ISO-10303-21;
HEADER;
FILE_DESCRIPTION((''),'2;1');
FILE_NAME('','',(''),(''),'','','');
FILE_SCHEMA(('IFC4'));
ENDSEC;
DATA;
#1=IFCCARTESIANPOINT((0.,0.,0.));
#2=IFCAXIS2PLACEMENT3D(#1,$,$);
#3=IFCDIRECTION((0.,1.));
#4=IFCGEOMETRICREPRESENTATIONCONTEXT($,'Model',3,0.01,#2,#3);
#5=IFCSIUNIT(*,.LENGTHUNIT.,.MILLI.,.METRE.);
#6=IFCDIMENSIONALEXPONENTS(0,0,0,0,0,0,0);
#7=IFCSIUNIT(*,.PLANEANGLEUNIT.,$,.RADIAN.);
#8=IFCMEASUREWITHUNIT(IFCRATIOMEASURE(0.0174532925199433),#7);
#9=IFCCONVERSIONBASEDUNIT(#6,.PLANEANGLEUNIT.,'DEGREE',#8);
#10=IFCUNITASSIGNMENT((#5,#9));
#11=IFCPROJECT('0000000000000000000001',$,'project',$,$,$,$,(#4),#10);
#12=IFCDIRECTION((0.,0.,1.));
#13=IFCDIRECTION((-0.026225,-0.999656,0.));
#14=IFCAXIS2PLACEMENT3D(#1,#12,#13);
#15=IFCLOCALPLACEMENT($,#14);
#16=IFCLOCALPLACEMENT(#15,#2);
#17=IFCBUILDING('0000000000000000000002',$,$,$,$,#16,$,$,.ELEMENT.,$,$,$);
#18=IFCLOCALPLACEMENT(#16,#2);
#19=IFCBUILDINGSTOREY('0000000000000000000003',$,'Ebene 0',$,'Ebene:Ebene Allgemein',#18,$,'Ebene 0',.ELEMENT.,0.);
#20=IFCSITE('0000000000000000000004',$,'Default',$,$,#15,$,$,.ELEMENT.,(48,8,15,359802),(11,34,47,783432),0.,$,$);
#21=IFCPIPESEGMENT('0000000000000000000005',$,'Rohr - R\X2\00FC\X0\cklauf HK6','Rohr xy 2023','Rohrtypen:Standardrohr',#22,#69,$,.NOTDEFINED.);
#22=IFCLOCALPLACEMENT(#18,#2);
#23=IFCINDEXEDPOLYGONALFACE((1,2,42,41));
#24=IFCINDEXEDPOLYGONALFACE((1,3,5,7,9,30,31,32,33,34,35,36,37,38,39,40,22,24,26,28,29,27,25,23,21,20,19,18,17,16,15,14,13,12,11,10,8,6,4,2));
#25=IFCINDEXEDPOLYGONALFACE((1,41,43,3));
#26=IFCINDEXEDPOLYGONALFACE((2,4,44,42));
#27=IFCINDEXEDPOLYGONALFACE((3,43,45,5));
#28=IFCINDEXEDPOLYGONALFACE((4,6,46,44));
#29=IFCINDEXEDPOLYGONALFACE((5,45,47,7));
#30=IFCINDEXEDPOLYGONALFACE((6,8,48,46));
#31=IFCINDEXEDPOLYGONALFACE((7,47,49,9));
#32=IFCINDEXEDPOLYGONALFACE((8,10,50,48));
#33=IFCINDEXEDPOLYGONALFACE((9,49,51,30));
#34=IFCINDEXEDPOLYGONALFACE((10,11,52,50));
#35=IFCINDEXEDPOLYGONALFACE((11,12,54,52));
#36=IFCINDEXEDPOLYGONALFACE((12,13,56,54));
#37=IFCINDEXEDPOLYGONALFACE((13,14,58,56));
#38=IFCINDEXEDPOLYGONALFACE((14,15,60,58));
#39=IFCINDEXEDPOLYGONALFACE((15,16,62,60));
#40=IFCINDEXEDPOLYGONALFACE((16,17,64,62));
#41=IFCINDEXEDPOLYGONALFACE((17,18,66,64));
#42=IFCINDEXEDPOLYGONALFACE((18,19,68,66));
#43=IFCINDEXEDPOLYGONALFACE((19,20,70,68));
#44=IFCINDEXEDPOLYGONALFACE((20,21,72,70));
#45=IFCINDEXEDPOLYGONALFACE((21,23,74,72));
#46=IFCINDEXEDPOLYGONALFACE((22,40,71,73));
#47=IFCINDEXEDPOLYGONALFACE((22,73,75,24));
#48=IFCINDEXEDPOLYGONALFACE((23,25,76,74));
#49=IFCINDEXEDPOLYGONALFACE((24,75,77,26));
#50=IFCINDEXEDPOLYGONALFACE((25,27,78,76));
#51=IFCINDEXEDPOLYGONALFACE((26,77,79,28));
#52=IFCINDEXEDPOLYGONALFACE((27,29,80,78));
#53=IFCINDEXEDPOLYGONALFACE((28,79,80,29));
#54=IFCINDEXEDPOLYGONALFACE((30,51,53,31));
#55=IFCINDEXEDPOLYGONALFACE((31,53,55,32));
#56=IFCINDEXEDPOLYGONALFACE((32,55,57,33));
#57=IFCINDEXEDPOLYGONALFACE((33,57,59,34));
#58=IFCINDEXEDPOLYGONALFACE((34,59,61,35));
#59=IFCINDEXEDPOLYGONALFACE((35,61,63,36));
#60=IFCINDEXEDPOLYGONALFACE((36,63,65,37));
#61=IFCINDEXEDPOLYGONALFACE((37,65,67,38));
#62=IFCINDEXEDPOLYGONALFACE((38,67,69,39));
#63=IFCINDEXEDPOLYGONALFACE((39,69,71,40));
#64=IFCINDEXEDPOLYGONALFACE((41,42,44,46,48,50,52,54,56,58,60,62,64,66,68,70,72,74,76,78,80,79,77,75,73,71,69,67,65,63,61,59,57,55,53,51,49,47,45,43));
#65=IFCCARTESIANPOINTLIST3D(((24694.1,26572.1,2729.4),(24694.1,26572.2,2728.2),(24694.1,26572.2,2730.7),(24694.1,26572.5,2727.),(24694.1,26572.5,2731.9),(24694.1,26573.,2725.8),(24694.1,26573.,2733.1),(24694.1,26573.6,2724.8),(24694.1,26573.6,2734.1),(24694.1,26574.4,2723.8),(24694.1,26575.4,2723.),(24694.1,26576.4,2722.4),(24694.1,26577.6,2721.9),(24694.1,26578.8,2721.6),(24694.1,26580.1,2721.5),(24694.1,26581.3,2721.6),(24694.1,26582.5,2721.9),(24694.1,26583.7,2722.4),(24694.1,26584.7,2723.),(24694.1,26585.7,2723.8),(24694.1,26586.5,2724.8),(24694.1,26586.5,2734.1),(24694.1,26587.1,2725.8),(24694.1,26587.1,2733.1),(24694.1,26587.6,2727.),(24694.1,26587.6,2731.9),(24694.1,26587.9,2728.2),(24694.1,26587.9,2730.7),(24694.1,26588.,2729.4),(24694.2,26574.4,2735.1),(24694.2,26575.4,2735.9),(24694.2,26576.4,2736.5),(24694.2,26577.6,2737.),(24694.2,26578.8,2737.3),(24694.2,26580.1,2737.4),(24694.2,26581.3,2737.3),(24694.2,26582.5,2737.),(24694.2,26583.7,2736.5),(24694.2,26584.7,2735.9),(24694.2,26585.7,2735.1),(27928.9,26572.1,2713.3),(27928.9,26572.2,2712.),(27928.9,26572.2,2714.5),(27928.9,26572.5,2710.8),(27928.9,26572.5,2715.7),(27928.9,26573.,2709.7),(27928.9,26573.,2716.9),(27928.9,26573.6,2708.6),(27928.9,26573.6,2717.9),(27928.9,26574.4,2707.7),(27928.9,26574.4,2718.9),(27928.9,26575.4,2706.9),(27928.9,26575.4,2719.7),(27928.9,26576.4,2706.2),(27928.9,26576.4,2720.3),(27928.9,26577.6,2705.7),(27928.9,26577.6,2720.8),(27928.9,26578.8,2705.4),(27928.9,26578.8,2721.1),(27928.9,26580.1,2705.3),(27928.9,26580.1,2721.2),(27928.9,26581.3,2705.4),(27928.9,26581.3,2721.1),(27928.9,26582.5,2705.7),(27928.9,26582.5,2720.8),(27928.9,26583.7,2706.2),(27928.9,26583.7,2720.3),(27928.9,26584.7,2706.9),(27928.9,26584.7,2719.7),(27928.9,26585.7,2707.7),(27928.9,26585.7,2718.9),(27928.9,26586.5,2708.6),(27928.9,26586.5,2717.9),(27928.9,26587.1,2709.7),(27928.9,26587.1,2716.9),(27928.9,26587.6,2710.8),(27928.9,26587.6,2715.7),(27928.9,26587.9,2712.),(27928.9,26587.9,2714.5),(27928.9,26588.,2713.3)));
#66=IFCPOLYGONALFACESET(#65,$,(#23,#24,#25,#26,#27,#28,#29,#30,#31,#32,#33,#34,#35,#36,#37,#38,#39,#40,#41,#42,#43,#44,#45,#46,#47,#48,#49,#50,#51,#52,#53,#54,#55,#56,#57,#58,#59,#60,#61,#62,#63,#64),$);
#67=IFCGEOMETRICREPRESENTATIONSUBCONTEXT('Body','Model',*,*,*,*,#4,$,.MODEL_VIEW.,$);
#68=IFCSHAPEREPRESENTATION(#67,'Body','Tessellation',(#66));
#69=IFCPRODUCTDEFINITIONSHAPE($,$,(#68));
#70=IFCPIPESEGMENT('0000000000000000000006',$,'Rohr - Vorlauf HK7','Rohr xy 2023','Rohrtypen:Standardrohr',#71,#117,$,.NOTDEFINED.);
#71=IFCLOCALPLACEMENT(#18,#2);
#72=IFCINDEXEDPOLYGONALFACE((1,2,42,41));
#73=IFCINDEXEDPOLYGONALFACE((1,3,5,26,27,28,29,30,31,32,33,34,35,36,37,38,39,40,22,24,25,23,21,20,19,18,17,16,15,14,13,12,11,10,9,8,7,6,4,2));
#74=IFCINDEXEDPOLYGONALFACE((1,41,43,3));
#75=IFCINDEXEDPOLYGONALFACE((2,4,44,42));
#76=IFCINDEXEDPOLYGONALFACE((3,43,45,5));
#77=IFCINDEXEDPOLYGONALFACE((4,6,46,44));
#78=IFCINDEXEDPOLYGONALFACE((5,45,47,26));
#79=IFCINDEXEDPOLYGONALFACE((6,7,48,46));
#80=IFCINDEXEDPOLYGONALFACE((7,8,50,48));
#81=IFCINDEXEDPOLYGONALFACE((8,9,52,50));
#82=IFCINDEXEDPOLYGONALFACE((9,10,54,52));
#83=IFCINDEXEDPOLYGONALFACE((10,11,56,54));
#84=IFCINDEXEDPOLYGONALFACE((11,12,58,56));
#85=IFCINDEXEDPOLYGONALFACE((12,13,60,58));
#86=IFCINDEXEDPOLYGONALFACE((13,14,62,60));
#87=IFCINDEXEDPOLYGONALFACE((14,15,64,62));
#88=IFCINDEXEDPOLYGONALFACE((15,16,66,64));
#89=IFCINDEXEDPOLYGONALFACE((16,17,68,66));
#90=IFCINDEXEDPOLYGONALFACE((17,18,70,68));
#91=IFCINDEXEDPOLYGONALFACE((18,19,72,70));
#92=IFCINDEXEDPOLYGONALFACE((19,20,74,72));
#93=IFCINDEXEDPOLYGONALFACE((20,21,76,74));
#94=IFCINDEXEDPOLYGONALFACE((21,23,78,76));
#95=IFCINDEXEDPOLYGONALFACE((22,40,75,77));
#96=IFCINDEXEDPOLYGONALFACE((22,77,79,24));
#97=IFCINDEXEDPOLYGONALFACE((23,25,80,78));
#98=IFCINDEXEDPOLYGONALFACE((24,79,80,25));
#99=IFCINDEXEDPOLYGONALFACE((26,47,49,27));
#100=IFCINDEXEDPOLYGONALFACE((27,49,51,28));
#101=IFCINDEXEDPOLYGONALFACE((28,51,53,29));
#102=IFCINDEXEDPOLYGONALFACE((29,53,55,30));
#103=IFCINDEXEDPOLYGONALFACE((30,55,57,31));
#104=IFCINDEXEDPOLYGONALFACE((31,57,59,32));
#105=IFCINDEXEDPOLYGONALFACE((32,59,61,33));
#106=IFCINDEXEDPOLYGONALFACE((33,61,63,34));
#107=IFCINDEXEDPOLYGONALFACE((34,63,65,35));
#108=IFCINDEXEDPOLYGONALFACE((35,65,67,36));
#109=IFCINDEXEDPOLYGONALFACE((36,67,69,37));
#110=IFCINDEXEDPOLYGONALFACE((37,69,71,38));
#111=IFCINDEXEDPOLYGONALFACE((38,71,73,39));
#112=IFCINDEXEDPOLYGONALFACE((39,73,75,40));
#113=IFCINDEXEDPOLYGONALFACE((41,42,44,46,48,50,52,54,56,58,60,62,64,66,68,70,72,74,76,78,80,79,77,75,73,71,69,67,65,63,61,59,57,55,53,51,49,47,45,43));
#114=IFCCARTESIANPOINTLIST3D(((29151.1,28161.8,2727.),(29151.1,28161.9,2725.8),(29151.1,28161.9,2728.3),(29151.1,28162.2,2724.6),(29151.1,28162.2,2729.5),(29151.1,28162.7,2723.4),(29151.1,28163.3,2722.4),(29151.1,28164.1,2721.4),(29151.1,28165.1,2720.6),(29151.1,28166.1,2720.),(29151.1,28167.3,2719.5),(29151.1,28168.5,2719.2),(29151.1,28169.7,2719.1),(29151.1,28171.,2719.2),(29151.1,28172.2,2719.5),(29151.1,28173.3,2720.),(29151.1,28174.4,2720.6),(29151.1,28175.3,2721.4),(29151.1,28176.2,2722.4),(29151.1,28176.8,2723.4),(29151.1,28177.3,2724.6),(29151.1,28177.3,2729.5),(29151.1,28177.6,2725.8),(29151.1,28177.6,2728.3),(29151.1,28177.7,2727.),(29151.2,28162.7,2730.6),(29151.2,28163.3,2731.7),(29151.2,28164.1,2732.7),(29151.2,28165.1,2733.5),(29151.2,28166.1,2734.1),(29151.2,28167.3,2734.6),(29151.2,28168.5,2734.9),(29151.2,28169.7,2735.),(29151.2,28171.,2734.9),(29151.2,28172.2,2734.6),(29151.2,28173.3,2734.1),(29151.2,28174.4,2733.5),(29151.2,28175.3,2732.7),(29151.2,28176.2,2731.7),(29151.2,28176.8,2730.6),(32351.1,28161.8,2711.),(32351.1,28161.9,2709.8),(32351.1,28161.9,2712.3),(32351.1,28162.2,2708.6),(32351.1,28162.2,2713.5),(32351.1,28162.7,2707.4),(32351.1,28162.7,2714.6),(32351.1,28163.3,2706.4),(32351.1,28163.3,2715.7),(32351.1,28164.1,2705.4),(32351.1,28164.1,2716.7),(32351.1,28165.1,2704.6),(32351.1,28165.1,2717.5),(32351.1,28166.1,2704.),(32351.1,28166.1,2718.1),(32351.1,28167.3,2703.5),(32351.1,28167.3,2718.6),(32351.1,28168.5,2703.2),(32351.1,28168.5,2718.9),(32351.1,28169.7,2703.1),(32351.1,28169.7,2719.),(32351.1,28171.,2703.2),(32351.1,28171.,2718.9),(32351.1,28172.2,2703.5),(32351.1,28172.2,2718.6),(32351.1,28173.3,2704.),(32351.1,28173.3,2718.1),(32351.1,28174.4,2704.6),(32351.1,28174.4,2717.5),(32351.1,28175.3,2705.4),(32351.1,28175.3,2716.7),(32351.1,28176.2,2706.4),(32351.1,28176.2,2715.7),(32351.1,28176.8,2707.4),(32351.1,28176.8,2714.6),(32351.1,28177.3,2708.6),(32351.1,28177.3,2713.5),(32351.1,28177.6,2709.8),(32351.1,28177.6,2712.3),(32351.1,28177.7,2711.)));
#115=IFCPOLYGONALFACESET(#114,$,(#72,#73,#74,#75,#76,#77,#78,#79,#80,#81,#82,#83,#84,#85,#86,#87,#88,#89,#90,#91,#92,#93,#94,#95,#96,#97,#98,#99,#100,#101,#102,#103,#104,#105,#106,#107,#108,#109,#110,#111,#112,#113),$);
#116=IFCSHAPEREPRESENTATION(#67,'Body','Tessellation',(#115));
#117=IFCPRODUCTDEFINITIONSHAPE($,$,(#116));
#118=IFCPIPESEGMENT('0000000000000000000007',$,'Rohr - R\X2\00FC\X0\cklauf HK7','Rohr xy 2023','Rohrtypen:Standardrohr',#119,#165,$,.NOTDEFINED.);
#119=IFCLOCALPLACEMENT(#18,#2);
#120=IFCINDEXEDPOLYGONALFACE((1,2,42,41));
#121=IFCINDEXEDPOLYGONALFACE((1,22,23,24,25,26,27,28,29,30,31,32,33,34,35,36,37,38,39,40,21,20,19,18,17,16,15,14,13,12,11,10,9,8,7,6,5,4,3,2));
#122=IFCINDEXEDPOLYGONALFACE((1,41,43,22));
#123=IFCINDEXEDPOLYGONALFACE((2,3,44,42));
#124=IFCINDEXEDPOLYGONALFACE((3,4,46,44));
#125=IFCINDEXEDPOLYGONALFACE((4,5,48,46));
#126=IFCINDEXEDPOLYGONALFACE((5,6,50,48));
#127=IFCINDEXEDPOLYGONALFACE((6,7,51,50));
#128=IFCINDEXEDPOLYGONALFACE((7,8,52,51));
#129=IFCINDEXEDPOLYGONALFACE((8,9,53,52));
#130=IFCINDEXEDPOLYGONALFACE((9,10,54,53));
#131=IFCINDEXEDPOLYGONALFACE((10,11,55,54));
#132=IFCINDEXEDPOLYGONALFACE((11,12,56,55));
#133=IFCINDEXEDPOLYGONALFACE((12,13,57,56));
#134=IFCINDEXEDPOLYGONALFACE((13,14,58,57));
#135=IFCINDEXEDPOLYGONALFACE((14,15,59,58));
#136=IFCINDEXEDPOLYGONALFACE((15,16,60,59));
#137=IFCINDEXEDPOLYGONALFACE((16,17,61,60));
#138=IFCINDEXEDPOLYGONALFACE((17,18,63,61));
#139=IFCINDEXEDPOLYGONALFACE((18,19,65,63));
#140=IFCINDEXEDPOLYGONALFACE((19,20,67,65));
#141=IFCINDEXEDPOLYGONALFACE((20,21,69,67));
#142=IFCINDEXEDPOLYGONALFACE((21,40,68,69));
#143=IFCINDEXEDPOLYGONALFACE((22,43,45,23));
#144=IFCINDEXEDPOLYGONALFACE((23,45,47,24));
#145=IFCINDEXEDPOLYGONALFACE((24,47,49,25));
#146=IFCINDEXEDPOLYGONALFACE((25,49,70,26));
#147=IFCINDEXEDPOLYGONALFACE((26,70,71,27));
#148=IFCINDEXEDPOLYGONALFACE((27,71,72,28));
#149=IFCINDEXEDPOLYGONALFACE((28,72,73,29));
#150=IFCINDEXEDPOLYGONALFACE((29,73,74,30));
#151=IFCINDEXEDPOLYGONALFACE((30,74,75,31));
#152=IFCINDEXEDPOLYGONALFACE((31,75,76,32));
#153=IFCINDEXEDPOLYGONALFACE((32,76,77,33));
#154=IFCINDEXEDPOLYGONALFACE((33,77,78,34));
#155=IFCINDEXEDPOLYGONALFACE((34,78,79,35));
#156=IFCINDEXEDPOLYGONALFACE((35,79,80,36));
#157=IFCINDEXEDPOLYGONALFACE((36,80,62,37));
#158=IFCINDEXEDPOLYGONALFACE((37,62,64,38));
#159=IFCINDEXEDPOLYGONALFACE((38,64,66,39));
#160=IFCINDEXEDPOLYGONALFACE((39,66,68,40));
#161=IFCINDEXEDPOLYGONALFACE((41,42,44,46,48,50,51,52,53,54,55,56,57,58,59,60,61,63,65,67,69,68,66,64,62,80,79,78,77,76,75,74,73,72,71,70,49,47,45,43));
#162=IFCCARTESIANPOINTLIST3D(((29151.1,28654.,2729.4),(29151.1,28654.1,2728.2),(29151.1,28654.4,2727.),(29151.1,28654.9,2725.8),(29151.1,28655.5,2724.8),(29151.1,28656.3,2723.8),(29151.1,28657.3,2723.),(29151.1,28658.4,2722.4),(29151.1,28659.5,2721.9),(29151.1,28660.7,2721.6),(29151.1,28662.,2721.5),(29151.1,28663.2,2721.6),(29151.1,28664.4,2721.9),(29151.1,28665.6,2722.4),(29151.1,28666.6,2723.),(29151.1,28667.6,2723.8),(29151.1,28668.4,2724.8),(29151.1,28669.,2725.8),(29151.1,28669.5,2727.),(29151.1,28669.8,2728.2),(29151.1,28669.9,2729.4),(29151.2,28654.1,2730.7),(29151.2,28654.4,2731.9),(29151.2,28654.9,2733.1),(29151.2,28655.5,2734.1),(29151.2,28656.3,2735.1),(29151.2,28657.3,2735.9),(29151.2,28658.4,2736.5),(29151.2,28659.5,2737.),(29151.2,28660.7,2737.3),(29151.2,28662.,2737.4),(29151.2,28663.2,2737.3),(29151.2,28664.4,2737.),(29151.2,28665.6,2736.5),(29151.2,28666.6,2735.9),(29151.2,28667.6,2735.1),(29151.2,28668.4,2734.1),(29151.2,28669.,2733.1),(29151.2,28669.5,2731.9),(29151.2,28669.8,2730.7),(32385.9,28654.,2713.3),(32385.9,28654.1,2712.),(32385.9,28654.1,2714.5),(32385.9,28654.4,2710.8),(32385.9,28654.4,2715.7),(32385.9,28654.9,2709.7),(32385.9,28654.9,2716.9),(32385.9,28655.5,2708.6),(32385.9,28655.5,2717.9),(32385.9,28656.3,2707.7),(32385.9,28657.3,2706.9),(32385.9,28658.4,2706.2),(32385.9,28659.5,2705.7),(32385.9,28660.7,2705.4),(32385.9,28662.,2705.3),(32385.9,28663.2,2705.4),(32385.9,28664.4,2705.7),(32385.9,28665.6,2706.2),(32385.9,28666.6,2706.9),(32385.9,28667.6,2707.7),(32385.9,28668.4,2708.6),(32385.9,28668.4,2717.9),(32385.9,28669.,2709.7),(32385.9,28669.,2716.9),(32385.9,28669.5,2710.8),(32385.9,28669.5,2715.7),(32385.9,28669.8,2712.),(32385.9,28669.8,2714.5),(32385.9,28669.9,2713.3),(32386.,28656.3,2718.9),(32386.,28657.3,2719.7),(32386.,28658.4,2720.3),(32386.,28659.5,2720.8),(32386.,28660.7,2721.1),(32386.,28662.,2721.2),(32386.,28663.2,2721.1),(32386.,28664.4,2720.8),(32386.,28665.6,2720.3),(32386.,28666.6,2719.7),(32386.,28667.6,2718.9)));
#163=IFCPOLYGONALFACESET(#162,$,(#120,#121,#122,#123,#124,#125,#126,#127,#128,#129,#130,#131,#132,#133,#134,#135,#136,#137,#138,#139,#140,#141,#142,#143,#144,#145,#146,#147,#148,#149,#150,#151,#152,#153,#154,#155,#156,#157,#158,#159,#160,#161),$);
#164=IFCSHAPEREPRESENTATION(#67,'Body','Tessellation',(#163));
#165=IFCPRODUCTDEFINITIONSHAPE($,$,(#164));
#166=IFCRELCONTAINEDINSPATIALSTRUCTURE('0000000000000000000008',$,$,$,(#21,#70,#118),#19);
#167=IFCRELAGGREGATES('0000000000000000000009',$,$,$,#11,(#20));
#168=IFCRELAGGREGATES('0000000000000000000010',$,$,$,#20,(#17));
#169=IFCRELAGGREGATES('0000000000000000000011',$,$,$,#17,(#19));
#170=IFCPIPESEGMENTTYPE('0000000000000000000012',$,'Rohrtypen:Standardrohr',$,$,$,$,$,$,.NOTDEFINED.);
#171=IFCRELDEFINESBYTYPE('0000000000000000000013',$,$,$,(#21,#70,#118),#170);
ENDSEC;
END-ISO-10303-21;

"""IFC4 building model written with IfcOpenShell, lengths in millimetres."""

from ifc_helpers import new_model, entity, si_unit, converted_unit, direction, frame, origin, place, context, subcontext, project, spatial, indexed_curve, outline, extrude, type_object, element, save


model = new_model("IFC4")

# Units and contexts
model_context = context("Model", 3, precision=0.01, world=origin(), true_north=direction((0.0, 1.0)))
body_context = subcontext(model_context, "Body", "Model", "MODEL_VIEW")
ifc_project = project(units=[si_unit("LENGTHUNIT", "METRE", prefix="MILLI"), converted_unit("PLANEANGLEUNIT", "DEGREE", entity("IfcRatioMeasure", 0.0174532925199433), si_unit("PLANEANGLEUNIT", "RADIAN"), dimensions=[0, 0, 0, 0, 0, 0, 0])], contexts=[model_context])

# Site, building, storey
site_placement = place(None, frame((0.0, 0.0, 0.0), z_axis=(0.0, 0.0, 1.0), x_axis=(-0.026225, -0.999656, 0.0)))
site = spatial("IfcSite", under=ifc_project, at=site_placement, Name="Default", CompositionType="ELEMENT", RefLatitude=(48, 8, 15, 359802), RefLongitude=(11, 34, 47, 783432), RefElevation=0.0)
building_placement = place(site_placement, origin())
building = spatial("IfcBuilding", under=site, at=building_placement, CompositionType="ELEMENT")
storey_placement = place(building_placement, origin())
storey = spatial("IfcBuildingStorey", under=building, at=storey_placement, Name="Ebene 0", ObjectType="Ebene:Ebene Allgemein", LongName="Ebene 0", CompositionType="ELEMENT", Elevation=0.0)

# Pipe segments
pipe_segment_type = type_object("IfcPipeSegmentType", Name="Rohrtypen:Standardrohr", PredefinedType="NOTDEFINED")
pipe_segment_1_placement = place(storey_placement, origin())
element("IfcPipeSegment", 1, at=pipe_segment_1_placement, inside=storey, type_object=pipe_segment_type, Name="Rohr - Rücklauf HK6", Description="Rohr xy 2023", ObjectType="Rohrtypen:Standardrohr", PredefinedType="NOTDEFINED", context=body_context, shape_type="SweptSolid", body=[
    extrude(outline(indexed_curve([(7.9, 0.0), (7.8, 1.2), (7.6, 2.5), (7.1, 3.6), (6.4, 4.7), (5.6, 5.6), (4.7, 6.4), (3.6, 7.1), (2.5, 7.6), (1.2, 7.8), (0.0, 7.9), (-1.2, 7.8), (-2.5, 7.6), (-3.6, 7.1), (-4.7, 6.4), (-5.6, 5.6), (-6.4, 4.7), (-7.1, 3.6), (-7.6, 2.5), (-7.8, 1.2), (-7.9, 0.0), (-7.8, -1.2), (-7.6, -2.5), (-7.1, -3.6), (-6.4, -4.7), (-5.6, -5.6), (-4.7, -6.4), (-3.6, -7.1), (-2.5, -7.6), (-1.2, -7.8), (0.0, -7.9), (1.2, -7.8), (2.5, -7.6), (3.6, -7.1), (4.7, -6.4), (5.6, -5.6), (6.4, -4.7), (7.1, -3.6), (7.6, -2.5), (7.8, -1.2), (7.9, 0.0)], self_intersect=False)), frame((27928.9, 26580.1, 2713.3), z_axis=(-0.999988, 0.0, 0.005), x_axis=(0.0, 1.0, 0.0)), (0.0, 0.0, 1.0), 3234.8),
])
pipe_segment_2_placement = place(storey_placement, origin())
element("IfcPipeSegment", 2, at=pipe_segment_2_placement, inside=storey, type_object=pipe_segment_type, Name="Rohr - Vorlauf HK7", Description="Rohr xy 2023", ObjectType="Rohrtypen:Standardrohr", PredefinedType="NOTDEFINED", context=body_context, shape_type="SweptSolid", body=[
    extrude(outline(indexed_curve([(7.9, 0.0), (7.8, 1.2), (7.6, 2.5), (7.1, 3.6), (6.4, 4.7), (5.6, 5.6), (4.7, 6.4), (3.6, 7.1), (2.5, 7.6), (1.2, 7.8), (0.0, 7.9), (-1.2, 7.8), (-2.5, 7.6), (-3.6, 7.1), (-4.7, 6.4), (-5.6, 5.6), (-6.4, 4.7), (-7.1, 3.6), (-7.6, 2.5), (-7.8, 1.2), (-7.9, 0.0), (-7.8, -1.2), (-7.6, -2.5), (-7.1, -3.6), (-6.4, -4.7), (-5.6, -5.6), (-4.7, -6.4), (-3.6, -7.1), (-2.5, -7.6), (-1.2, -7.8), (0.0, -7.9), (1.2, -7.8), (2.5, -7.6), (3.6, -7.1), (4.7, -6.4), (5.6, -5.6), (6.4, -4.7), (7.1, -3.6), (7.6, -2.5), (7.8, -1.2), (7.9, 0.0)], self_intersect=False)), frame((32351.1, 28169.7, 2711.0), z_axis=(-0.999988, 0.0, 0.005), x_axis=(0.0, 1.0, 0.0)), (0.0, 0.0, 1.0), 3200.0),
])
pipe_segment_3_placement = place(storey_placement, origin())
element("IfcPipeSegment", 3, at=pipe_segment_3_placement, inside=storey, type_object=pipe_segment_type, Name="Rohr - Rücklauf HK7", Description="Rohr xy 2023", ObjectType="Rohrtypen:Standardrohr", PredefinedType="NOTDEFINED", context=body_context, shape_type="SweptSolid", body=[
    extrude(outline(indexed_curve([(7.9, 0.0), (7.8, 1.2), (7.6, 2.5), (7.1, 3.6), (6.4, 4.7), (5.6, 5.6), (4.7, 6.4), (3.6, 7.1), (2.5, 7.6), (1.2, 7.8), (0.0, 7.9), (-1.2, 7.8), (-2.5, 7.6), (-3.6, 7.1), (-4.7, 6.4), (-5.6, 5.6), (-6.4, 4.7), (-7.1, 3.6), (-7.6, 2.5), (-7.8, 1.2), (-7.9, 0.0), (-7.8, -1.2), (-7.6, -2.5), (-7.1, -3.6), (-6.4, -4.7), (-5.6, -5.6), (-4.7, -6.4), (-3.6, -7.1), (-2.5, -7.6), (-1.2, -7.8), (0.0, -7.9), (1.2, -7.8), (2.5, -7.6), (3.6, -7.1), (4.7, -6.4), (5.6, -5.6), (6.4, -4.7), (7.1, -3.6), (7.6, -2.5), (7.8, -1.2), (7.9, 0.0)], self_intersect=False)), frame((32385.9, 28662.0, 2713.3), z_axis=(-0.999988, 0.0, 0.005), x_axis=(0.0, 1.0, 0.0)), (0.0, 0.0, 1.0), 3234.8),
])

save(model, "model.ifc")
